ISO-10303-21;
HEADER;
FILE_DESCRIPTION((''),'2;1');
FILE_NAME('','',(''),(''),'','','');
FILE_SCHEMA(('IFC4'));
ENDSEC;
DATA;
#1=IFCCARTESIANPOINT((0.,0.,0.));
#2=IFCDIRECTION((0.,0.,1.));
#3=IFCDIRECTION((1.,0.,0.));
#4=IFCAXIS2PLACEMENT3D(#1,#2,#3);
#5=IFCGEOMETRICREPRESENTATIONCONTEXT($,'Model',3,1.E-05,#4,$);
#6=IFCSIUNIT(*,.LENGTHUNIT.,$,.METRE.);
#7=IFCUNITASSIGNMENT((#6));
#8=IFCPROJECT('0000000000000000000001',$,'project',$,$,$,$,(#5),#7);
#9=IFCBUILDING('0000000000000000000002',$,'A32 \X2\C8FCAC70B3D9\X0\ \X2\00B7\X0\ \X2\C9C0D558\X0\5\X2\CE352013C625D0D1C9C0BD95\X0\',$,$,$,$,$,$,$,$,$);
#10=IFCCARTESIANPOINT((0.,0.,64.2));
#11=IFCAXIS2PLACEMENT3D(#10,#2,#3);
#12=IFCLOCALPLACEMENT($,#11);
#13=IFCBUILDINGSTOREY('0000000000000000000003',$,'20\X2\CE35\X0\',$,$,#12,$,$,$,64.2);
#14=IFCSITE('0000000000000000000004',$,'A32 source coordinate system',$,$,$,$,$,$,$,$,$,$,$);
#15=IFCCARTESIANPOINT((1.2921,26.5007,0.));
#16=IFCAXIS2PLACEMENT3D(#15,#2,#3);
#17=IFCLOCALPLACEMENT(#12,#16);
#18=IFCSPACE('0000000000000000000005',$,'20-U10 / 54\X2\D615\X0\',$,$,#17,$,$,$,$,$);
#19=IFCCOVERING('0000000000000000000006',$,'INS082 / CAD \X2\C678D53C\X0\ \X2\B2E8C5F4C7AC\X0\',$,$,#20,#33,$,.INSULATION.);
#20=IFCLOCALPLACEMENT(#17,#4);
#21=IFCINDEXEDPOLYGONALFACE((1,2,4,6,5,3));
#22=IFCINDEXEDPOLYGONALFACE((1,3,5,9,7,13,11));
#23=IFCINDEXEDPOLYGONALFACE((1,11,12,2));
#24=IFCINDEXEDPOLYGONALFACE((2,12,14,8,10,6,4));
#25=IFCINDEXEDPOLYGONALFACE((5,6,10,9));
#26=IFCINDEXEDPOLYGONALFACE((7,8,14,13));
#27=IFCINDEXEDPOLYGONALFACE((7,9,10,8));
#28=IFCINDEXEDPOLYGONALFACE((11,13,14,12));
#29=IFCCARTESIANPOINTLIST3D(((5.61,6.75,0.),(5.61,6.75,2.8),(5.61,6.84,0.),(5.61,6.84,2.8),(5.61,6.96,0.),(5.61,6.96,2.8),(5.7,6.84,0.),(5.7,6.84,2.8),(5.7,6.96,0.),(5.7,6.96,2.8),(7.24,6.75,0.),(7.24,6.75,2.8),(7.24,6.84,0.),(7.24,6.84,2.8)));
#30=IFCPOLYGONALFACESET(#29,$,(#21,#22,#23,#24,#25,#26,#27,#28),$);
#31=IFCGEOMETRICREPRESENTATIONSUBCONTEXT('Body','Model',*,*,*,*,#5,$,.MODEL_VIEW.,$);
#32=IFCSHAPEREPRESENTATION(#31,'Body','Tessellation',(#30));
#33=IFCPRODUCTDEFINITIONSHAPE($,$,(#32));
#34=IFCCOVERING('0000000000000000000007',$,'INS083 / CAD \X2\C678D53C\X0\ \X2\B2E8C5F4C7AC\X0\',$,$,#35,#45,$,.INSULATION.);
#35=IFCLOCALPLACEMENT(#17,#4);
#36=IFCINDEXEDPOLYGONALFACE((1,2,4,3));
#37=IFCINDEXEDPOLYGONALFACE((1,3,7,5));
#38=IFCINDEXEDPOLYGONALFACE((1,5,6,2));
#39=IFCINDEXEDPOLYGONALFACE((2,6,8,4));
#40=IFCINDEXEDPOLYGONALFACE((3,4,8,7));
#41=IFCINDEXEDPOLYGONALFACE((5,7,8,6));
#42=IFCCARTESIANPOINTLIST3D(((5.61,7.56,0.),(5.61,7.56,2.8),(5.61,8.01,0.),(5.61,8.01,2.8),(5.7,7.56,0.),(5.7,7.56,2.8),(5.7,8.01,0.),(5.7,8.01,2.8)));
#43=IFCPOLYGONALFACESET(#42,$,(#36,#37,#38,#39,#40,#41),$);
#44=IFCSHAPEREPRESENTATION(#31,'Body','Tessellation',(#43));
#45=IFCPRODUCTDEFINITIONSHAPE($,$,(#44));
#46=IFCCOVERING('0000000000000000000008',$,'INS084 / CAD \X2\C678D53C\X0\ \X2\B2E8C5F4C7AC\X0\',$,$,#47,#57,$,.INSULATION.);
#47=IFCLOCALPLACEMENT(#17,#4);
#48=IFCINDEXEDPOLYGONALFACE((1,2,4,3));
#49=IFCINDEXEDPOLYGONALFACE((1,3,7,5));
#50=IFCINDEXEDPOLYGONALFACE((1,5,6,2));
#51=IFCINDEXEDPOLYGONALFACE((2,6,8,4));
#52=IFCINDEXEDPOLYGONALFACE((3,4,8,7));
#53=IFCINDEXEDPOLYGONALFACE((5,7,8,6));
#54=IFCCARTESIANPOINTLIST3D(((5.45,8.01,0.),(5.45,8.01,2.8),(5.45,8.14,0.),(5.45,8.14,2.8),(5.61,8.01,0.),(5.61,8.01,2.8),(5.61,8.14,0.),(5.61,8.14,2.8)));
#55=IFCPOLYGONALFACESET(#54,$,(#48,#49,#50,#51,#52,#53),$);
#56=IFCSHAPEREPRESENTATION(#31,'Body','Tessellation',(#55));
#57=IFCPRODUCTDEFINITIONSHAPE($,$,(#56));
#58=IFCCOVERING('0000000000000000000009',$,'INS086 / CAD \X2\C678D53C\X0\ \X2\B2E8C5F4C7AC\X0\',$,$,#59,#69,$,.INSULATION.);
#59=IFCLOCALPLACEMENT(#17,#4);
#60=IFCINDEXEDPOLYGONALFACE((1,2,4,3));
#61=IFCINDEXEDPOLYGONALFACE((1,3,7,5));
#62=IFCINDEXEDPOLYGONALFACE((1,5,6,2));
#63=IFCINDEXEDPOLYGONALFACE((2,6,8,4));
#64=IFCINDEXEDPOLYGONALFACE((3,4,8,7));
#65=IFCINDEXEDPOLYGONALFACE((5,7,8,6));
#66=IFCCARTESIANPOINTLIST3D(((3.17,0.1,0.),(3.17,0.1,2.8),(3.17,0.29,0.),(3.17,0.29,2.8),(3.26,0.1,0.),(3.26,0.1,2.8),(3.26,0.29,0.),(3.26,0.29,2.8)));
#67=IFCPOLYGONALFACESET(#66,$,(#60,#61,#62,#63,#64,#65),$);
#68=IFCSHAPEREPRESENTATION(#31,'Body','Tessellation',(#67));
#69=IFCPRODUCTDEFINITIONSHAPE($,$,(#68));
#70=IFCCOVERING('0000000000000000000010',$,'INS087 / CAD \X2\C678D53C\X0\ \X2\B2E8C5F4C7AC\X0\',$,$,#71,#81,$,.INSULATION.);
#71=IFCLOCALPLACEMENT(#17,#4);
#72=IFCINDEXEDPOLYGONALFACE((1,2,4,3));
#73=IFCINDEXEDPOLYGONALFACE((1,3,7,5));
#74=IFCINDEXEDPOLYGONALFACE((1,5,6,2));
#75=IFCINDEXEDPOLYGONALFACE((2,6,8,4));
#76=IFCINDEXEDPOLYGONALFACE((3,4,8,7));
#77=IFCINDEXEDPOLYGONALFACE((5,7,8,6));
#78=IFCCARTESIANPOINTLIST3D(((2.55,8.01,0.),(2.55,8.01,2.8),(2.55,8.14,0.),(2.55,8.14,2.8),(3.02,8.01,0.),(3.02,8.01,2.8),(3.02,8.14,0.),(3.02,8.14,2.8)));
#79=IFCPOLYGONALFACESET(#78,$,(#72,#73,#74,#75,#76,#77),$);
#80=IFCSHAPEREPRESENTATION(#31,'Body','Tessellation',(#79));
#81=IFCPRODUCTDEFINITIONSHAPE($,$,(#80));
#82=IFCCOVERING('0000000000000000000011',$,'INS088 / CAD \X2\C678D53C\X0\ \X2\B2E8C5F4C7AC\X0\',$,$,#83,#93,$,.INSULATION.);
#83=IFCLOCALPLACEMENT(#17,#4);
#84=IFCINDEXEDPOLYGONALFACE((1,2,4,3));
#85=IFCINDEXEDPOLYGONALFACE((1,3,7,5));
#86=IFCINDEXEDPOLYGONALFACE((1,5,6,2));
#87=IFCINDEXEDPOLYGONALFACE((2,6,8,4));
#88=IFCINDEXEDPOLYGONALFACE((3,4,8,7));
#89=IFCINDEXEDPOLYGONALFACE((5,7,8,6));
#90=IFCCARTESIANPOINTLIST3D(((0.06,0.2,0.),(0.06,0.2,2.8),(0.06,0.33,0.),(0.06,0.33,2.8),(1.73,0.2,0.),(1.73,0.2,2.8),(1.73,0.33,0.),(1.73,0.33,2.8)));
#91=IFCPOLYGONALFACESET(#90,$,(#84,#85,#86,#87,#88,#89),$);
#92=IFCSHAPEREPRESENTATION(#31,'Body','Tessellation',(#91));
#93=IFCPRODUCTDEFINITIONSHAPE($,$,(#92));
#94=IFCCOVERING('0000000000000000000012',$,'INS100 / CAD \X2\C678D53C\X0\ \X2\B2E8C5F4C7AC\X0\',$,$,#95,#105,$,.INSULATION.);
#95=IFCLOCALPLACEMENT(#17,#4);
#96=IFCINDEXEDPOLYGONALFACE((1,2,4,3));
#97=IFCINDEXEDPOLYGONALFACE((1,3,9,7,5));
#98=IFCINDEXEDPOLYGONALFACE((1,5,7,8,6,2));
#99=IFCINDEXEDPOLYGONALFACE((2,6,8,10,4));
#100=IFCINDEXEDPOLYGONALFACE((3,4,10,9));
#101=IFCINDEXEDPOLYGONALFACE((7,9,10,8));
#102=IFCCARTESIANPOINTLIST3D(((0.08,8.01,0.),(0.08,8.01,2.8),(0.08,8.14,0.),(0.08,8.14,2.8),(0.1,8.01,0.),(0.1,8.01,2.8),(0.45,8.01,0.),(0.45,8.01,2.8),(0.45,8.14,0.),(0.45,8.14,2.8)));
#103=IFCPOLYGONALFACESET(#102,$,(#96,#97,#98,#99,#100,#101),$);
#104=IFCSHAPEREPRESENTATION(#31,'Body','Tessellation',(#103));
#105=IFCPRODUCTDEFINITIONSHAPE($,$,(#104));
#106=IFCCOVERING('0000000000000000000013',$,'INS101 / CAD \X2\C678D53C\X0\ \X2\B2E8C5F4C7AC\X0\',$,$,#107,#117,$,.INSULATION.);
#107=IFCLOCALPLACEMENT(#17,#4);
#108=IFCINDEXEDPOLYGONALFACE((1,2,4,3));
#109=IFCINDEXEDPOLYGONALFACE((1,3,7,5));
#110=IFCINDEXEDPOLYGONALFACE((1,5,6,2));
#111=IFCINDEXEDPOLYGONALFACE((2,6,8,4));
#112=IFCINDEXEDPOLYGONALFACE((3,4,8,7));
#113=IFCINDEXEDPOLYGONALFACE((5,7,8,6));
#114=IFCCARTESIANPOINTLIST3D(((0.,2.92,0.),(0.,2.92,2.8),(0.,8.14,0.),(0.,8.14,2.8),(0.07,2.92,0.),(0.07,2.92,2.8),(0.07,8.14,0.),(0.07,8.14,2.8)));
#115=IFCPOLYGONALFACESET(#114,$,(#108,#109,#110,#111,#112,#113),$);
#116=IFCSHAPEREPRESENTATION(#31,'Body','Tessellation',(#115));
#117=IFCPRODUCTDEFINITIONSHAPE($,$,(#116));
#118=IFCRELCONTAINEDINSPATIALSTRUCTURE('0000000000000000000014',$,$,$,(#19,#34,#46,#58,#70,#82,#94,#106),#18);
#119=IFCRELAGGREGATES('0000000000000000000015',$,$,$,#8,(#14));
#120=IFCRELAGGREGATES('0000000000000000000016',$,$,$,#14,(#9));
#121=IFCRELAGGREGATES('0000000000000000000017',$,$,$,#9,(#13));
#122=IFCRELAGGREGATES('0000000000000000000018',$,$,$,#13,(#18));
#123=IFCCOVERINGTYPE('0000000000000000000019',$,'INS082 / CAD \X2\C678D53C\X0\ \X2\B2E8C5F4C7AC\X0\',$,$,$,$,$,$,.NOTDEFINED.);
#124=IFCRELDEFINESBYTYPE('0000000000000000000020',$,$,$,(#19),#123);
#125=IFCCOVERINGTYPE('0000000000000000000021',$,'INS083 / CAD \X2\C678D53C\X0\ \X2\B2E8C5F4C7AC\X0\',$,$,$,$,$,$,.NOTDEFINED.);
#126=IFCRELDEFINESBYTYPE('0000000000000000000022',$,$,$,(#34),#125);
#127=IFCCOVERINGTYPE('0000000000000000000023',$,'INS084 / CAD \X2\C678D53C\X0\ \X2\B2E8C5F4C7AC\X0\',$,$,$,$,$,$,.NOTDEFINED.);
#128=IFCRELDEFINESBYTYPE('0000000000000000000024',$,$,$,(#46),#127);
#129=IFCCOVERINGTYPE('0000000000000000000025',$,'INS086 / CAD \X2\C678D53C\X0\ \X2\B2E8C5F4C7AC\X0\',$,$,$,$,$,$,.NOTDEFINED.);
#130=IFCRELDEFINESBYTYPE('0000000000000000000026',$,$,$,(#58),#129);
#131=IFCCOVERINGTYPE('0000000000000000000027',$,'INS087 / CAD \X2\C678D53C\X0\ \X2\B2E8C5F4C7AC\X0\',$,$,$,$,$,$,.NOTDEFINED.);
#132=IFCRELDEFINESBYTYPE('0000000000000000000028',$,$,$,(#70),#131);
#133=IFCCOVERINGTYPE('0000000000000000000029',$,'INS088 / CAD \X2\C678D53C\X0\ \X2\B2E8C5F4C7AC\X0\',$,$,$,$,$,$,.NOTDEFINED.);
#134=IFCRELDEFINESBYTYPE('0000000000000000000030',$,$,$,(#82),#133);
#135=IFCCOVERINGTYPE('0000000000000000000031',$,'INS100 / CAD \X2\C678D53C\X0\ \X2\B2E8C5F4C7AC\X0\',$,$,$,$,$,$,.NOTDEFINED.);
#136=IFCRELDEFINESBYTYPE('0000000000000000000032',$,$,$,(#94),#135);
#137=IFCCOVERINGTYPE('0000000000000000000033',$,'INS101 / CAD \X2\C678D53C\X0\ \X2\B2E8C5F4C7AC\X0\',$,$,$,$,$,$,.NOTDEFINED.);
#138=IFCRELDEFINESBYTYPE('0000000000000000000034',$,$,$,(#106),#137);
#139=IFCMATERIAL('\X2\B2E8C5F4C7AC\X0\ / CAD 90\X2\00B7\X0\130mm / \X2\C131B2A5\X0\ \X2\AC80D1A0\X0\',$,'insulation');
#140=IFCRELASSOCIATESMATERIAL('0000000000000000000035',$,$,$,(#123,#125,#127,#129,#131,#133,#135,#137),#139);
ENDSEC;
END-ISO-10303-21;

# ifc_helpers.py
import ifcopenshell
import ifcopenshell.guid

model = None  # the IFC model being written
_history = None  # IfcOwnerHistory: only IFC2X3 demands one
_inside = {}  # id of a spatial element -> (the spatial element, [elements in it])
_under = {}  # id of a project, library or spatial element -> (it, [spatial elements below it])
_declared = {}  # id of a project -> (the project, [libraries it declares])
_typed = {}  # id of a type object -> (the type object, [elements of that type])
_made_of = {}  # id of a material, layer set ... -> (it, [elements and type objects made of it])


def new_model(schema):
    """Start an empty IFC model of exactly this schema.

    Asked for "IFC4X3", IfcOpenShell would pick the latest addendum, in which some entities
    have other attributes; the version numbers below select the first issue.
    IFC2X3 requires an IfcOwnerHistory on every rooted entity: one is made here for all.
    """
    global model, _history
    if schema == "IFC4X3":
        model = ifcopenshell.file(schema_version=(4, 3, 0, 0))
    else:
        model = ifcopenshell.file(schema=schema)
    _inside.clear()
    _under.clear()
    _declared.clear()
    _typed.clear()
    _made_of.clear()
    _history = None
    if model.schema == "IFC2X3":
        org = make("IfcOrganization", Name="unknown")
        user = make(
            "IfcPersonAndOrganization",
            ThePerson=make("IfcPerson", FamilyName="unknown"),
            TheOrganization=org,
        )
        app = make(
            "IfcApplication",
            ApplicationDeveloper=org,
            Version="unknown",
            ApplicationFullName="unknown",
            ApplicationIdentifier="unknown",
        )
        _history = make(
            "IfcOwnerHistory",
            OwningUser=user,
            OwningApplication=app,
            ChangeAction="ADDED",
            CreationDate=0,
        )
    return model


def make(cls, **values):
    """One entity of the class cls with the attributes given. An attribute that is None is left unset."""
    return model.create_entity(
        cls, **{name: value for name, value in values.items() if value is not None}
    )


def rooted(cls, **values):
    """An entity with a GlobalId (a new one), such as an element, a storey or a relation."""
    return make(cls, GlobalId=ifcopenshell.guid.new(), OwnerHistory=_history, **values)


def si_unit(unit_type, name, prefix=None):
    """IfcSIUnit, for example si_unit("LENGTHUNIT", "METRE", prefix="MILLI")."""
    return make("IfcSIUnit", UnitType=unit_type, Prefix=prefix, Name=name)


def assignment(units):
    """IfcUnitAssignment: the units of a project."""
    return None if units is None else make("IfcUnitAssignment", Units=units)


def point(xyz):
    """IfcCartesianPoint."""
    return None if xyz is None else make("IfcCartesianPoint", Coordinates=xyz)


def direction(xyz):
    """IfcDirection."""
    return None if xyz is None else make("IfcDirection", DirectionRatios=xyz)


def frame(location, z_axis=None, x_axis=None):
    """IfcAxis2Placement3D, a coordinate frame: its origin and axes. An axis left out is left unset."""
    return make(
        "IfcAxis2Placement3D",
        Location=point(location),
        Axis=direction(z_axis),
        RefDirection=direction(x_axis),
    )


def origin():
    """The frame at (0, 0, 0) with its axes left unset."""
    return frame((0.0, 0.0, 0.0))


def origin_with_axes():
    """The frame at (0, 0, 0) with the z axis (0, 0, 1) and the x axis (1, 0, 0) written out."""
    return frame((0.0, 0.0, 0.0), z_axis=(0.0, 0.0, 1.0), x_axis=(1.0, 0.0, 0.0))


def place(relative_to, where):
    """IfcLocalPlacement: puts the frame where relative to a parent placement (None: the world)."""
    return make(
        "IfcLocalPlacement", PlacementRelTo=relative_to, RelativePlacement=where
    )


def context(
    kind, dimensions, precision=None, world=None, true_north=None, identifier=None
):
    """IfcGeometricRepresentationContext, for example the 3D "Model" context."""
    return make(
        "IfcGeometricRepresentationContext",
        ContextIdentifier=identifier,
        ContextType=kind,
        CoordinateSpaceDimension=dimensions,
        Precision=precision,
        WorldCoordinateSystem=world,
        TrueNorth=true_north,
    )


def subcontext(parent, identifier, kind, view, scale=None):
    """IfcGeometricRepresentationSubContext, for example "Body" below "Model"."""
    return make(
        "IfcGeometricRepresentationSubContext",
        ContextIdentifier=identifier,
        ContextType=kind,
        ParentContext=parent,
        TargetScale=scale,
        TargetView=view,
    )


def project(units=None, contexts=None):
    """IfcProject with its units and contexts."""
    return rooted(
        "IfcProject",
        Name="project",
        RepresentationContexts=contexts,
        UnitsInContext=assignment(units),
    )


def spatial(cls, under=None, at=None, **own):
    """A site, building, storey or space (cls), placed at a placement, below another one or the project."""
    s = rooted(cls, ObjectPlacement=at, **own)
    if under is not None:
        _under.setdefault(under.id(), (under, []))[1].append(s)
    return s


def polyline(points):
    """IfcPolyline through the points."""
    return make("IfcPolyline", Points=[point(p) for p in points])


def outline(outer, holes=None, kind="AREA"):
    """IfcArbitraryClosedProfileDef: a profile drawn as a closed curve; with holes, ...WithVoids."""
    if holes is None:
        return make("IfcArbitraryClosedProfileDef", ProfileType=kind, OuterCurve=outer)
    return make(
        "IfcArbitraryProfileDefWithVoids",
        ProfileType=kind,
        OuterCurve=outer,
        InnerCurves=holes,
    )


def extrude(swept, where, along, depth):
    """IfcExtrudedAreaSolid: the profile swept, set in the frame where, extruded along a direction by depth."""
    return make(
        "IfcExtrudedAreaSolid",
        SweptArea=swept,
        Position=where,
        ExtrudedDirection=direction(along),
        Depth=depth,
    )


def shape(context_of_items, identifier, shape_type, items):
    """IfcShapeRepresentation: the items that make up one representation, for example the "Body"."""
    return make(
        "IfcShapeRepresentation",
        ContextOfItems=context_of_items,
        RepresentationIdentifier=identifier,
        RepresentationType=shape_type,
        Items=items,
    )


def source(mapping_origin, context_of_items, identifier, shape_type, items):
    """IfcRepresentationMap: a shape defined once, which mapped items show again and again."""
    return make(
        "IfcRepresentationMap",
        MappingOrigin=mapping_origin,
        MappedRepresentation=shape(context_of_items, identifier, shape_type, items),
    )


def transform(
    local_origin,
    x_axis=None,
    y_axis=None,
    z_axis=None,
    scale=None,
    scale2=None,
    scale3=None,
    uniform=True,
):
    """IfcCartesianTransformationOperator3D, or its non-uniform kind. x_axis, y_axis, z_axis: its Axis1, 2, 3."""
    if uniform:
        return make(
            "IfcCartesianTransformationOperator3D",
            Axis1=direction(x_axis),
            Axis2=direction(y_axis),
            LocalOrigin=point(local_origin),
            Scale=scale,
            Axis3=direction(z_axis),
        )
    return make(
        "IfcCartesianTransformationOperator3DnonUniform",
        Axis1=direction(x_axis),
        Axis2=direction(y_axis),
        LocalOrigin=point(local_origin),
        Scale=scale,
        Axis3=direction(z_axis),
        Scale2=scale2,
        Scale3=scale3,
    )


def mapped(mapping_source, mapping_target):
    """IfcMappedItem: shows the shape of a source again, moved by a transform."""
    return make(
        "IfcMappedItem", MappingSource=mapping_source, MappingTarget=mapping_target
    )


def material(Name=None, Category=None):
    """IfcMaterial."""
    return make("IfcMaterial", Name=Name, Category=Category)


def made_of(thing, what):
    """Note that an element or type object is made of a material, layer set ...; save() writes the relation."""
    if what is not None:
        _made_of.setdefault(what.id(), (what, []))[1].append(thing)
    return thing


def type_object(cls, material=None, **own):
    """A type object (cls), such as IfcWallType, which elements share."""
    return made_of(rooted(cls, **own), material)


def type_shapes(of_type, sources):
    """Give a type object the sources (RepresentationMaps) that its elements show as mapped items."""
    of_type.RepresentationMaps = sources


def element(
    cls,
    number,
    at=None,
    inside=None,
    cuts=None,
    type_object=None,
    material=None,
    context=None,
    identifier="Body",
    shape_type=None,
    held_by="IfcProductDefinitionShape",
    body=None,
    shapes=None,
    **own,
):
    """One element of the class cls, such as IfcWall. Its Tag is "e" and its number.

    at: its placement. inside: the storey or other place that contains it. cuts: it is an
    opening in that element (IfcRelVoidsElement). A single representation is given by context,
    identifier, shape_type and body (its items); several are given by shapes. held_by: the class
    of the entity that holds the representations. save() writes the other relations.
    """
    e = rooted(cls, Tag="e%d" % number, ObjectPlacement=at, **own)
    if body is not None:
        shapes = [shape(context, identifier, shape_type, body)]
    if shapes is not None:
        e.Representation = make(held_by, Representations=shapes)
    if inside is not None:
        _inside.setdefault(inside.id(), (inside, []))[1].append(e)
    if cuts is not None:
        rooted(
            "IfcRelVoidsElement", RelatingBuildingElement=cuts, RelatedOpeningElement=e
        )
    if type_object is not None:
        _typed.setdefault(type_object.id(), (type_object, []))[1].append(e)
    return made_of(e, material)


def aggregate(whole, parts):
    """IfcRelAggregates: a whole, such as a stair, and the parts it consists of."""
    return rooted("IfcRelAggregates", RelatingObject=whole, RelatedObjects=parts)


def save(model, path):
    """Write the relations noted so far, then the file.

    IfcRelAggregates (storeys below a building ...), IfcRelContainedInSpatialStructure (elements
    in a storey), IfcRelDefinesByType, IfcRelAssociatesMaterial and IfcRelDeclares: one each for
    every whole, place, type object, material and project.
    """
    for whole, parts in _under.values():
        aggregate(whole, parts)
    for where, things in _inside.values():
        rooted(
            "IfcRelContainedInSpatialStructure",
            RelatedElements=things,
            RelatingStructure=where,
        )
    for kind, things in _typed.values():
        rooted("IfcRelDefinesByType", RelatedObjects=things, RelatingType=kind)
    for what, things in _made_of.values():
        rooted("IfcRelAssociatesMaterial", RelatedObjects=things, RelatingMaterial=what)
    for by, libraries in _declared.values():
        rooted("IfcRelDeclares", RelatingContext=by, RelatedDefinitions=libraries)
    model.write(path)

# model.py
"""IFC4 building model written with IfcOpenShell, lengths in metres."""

from ifc_helpers import new_model, si_unit, frame, origin, origin_with_axes, place, context, subcontext, project, spatial, polyline, outline, extrude, source, transform, mapped, material, type_object, type_shapes, element, save


model = new_model("IFC4")

# Units and contexts
model_context = context("Model", 3, precision=1e-05, world=origin_with_axes())
body_context = subcontext(model_context, "Body", "Model", "MODEL_VIEW")
ifc_project = project(units=[si_unit("LENGTHUNIT", "METRE")], contexts=[model_context])

# Site, building, storey, space
storey_placement = place(None, frame((0.0, 0.0, 64.2), z_axis=(0.0, 0.0, 1.0), x_axis=(1.0, 0.0, 0.0)))
space_placement = place(storey_placement, frame((1.2921, 26.5007, 0.0), z_axis=(0.0, 0.0, 1.0), x_axis=(1.0, 0.0, 0.0)))
site = spatial("IfcSite", under=ifc_project, Name="A32 source coordinate system")
building = spatial("IfcBuilding", under=site, Name="A32 주거동 · 지하5층–옥탑지붕")
storey = spatial("IfcBuildingStorey", under=building, at=storey_placement, Name="20층", Elevation=64.2)
space = spatial("IfcSpace", under=storey, at=space_placement, Name="20-U10 / 54형")

# Coverings
ifc_material = material(Name="단열재 / CAD 90·130mm / 성능 검토", Category="insulation")
covering_type_1 = type_object("IfcCoveringType", Name="INS082 / CAD 외피 단열재", PredefinedType="NOTDEFINED", material=ifc_material)
shared_shape_1 = source(origin(), body_context, "Body", "SweptSolid", [
    extrude(outline(polyline([(5.61, 6.84), (5.61, 6.96), (5.7, 6.96), (5.7, 6.84), (7.24, 6.84), (7.24, 6.75), (5.61, 6.75), (5.61, 6.84)])), origin(), (0.0, 0.0, 1.0), 2.8),
])
type_shapes(covering_type_1, [shared_shape_1])
covering_1_placement = place(space_placement, origin_with_axes())
element("IfcCovering", 1, at=covering_1_placement, inside=space, type_object=covering_type_1, Name="INS082 / CAD 외피 단열재", PredefinedType="INSULATION", context=body_context, shape_type="MappedRepresentation", body=[
    mapped(shared_shape_1, transform((0.0, 0.0, 0.0), scale=1.0)),
])
covering_type_2 = type_object("IfcCoveringType", Name="INS083 / CAD 외피 단열재", PredefinedType="NOTDEFINED", material=ifc_material)
shared_shape_2 = source(origin(), body_context, "Body", "SweptSolid", [
    extrude(outline(polyline([(5.61, 8.01), (5.7, 8.01), (5.7, 7.56), (5.61, 7.56), (5.61, 8.01)])), origin(), (0.0, 0.0, 1.0), 2.8),
])
type_shapes(covering_type_2, [shared_shape_2])
covering_2_placement = place(space_placement, origin_with_axes())
element("IfcCovering", 2, at=covering_2_placement, inside=space, type_object=covering_type_2, Name="INS083 / CAD 외피 단열재", PredefinedType="INSULATION", context=body_context, shape_type="MappedRepresentation", body=[
    mapped(shared_shape_2, transform((0.0, 0.0, 0.0), scale=1.0)),
])
covering_type_3 = type_object("IfcCoveringType", Name="INS084 / CAD 외피 단열재", PredefinedType="NOTDEFINED", material=ifc_material)
shared_shape_3 = source(origin(), body_context, "Body", "SweptSolid", [
    extrude(outline(polyline([(5.45, 8.01), (5.45, 8.14), (5.61, 8.14), (5.61, 8.01), (5.45, 8.01)])), origin(), (0.0, 0.0, 1.0), 2.8),
])
type_shapes(covering_type_3, [shared_shape_3])
covering_3_placement = place(space_placement, origin_with_axes())
element("IfcCovering", 3, at=covering_3_placement, inside=space, type_object=covering_type_3, Name="INS084 / CAD 외피 단열재", PredefinedType="INSULATION", context=body_context, shape_type="MappedRepresentation", body=[
    mapped(shared_shape_3, transform((0.0, 0.0, 0.0), scale=1.0)),
])
covering_type_4 = type_object("IfcCoveringType", Name="INS086 / CAD 외피 단열재", PredefinedType="NOTDEFINED", material=ifc_material)
shared_shape_4 = source(origin(), body_context, "Body", "SweptSolid", [
    extrude(outline(polyline([(3.17, 0.1), (3.17, 0.29), (3.26, 0.29), (3.26, 0.1), (3.17, 0.1)])), origin(), (0.0, 0.0, 1.0), 2.8),
])
type_shapes(covering_type_4, [shared_shape_4])
covering_4_placement = place(space_placement, origin_with_axes())
element("IfcCovering", 4, at=covering_4_placement, inside=space, type_object=covering_type_4, Name="INS086 / CAD 외피 단열재", PredefinedType="INSULATION", context=body_context, shape_type="MappedRepresentation", body=[
    mapped(shared_shape_4, transform((0.0, 0.0, 0.0), scale=1.0)),
])
covering_type_5 = type_object("IfcCoveringType", Name="INS087 / CAD 외피 단열재", PredefinedType="NOTDEFINED", material=ifc_material)
shared_shape_5 = source(origin(), body_context, "Body", "SweptSolid", [
    extrude(outline(polyline([(2.55, 8.14), (3.02, 8.14), (3.02, 8.01), (2.55, 8.01), (2.55, 8.14)])), origin(), (0.0, 0.0, 1.0), 2.8),
])
type_shapes(covering_type_5, [shared_shape_5])
covering_5_placement = place(space_placement, origin_with_axes())
element("IfcCovering", 5, at=covering_5_placement, inside=space, type_object=covering_type_5, Name="INS087 / CAD 외피 단열재", PredefinedType="INSULATION", context=body_context, shape_type="MappedRepresentation", body=[
    mapped(shared_shape_5, transform((0.0, 0.0, 0.0), scale=1.0)),
])
covering_type_6 = type_object("IfcCoveringType", Name="INS088 / CAD 외피 단열재", PredefinedType="NOTDEFINED", material=ifc_material)
shared_shape_6 = source(origin(), body_context, "Body", "SweptSolid", [
    extrude(outline(polyline([(0.06, 0.33), (1.73, 0.33), (1.73, 0.2), (0.06, 0.2), (0.06, 0.33)])), origin(), (0.0, 0.0, 1.0), 2.8),
])
type_shapes(covering_type_6, [shared_shape_6])
covering_6_placement = place(space_placement, origin_with_axes())
element("IfcCovering", 6, at=covering_6_placement, inside=space, type_object=covering_type_6, Name="INS088 / CAD 외피 단열재", PredefinedType="INSULATION", context=body_context, shape_type="MappedRepresentation", body=[
    mapped(shared_shape_6, transform((0.0, 0.0, 0.0), scale=1.0)),
])
covering_type_7 = type_object("IfcCoveringType", Name="INS100 / CAD 외피 단열재", PredefinedType="NOTDEFINED", material=ifc_material)
shared_shape_7 = source(origin(), body_context, "Body", "SweptSolid", [
    extrude(outline(polyline([(0.08, 8.01), (0.08, 8.14), (0.45, 8.14), (0.45, 8.01), (0.1, 8.01), (0.08, 8.01)])), origin(), (0.0, 0.0, 1.0), 2.8),
])
type_shapes(covering_type_7, [shared_shape_7])
covering_7_placement = place(space_placement, origin_with_axes())
element("IfcCovering", 7, at=covering_7_placement, inside=space, type_object=covering_type_7, Name="INS100 / CAD 외피 단열재", PredefinedType="INSULATION", context=body_context, shape_type="MappedRepresentation", body=[
    mapped(shared_shape_7, transform((0.0, 0.0, 0.0), scale=1.0)),
])
covering_type_8 = type_object("IfcCoveringType", Name="INS101 / CAD 외피 단열재", PredefinedType="NOTDEFINED", material=ifc_material)
shared_shape_8 = source(origin(), body_context, "Body", "SweptSolid", [
    extrude(outline(polyline([(0.0, 2.92), (0.0, 8.14), (0.07, 8.14), (0.07, 2.92), (0.0, 2.92)])), origin(), (0.0, 0.0, 1.0), 2.8),
])
type_shapes(covering_type_8, [shared_shape_8])
covering_8_placement = place(space_placement, origin_with_axes())
element("IfcCovering", 8, at=covering_8_placement, inside=space, type_object=covering_type_8, Name="INS101 / CAD 외피 단열재", PredefinedType="INSULATION", context=body_context, shape_type="MappedRepresentation", body=[
    mapped(shared_shape_8, transform((0.0, 0.0, 0.0), scale=1.0)),
])

save(model, "model.ifc")
